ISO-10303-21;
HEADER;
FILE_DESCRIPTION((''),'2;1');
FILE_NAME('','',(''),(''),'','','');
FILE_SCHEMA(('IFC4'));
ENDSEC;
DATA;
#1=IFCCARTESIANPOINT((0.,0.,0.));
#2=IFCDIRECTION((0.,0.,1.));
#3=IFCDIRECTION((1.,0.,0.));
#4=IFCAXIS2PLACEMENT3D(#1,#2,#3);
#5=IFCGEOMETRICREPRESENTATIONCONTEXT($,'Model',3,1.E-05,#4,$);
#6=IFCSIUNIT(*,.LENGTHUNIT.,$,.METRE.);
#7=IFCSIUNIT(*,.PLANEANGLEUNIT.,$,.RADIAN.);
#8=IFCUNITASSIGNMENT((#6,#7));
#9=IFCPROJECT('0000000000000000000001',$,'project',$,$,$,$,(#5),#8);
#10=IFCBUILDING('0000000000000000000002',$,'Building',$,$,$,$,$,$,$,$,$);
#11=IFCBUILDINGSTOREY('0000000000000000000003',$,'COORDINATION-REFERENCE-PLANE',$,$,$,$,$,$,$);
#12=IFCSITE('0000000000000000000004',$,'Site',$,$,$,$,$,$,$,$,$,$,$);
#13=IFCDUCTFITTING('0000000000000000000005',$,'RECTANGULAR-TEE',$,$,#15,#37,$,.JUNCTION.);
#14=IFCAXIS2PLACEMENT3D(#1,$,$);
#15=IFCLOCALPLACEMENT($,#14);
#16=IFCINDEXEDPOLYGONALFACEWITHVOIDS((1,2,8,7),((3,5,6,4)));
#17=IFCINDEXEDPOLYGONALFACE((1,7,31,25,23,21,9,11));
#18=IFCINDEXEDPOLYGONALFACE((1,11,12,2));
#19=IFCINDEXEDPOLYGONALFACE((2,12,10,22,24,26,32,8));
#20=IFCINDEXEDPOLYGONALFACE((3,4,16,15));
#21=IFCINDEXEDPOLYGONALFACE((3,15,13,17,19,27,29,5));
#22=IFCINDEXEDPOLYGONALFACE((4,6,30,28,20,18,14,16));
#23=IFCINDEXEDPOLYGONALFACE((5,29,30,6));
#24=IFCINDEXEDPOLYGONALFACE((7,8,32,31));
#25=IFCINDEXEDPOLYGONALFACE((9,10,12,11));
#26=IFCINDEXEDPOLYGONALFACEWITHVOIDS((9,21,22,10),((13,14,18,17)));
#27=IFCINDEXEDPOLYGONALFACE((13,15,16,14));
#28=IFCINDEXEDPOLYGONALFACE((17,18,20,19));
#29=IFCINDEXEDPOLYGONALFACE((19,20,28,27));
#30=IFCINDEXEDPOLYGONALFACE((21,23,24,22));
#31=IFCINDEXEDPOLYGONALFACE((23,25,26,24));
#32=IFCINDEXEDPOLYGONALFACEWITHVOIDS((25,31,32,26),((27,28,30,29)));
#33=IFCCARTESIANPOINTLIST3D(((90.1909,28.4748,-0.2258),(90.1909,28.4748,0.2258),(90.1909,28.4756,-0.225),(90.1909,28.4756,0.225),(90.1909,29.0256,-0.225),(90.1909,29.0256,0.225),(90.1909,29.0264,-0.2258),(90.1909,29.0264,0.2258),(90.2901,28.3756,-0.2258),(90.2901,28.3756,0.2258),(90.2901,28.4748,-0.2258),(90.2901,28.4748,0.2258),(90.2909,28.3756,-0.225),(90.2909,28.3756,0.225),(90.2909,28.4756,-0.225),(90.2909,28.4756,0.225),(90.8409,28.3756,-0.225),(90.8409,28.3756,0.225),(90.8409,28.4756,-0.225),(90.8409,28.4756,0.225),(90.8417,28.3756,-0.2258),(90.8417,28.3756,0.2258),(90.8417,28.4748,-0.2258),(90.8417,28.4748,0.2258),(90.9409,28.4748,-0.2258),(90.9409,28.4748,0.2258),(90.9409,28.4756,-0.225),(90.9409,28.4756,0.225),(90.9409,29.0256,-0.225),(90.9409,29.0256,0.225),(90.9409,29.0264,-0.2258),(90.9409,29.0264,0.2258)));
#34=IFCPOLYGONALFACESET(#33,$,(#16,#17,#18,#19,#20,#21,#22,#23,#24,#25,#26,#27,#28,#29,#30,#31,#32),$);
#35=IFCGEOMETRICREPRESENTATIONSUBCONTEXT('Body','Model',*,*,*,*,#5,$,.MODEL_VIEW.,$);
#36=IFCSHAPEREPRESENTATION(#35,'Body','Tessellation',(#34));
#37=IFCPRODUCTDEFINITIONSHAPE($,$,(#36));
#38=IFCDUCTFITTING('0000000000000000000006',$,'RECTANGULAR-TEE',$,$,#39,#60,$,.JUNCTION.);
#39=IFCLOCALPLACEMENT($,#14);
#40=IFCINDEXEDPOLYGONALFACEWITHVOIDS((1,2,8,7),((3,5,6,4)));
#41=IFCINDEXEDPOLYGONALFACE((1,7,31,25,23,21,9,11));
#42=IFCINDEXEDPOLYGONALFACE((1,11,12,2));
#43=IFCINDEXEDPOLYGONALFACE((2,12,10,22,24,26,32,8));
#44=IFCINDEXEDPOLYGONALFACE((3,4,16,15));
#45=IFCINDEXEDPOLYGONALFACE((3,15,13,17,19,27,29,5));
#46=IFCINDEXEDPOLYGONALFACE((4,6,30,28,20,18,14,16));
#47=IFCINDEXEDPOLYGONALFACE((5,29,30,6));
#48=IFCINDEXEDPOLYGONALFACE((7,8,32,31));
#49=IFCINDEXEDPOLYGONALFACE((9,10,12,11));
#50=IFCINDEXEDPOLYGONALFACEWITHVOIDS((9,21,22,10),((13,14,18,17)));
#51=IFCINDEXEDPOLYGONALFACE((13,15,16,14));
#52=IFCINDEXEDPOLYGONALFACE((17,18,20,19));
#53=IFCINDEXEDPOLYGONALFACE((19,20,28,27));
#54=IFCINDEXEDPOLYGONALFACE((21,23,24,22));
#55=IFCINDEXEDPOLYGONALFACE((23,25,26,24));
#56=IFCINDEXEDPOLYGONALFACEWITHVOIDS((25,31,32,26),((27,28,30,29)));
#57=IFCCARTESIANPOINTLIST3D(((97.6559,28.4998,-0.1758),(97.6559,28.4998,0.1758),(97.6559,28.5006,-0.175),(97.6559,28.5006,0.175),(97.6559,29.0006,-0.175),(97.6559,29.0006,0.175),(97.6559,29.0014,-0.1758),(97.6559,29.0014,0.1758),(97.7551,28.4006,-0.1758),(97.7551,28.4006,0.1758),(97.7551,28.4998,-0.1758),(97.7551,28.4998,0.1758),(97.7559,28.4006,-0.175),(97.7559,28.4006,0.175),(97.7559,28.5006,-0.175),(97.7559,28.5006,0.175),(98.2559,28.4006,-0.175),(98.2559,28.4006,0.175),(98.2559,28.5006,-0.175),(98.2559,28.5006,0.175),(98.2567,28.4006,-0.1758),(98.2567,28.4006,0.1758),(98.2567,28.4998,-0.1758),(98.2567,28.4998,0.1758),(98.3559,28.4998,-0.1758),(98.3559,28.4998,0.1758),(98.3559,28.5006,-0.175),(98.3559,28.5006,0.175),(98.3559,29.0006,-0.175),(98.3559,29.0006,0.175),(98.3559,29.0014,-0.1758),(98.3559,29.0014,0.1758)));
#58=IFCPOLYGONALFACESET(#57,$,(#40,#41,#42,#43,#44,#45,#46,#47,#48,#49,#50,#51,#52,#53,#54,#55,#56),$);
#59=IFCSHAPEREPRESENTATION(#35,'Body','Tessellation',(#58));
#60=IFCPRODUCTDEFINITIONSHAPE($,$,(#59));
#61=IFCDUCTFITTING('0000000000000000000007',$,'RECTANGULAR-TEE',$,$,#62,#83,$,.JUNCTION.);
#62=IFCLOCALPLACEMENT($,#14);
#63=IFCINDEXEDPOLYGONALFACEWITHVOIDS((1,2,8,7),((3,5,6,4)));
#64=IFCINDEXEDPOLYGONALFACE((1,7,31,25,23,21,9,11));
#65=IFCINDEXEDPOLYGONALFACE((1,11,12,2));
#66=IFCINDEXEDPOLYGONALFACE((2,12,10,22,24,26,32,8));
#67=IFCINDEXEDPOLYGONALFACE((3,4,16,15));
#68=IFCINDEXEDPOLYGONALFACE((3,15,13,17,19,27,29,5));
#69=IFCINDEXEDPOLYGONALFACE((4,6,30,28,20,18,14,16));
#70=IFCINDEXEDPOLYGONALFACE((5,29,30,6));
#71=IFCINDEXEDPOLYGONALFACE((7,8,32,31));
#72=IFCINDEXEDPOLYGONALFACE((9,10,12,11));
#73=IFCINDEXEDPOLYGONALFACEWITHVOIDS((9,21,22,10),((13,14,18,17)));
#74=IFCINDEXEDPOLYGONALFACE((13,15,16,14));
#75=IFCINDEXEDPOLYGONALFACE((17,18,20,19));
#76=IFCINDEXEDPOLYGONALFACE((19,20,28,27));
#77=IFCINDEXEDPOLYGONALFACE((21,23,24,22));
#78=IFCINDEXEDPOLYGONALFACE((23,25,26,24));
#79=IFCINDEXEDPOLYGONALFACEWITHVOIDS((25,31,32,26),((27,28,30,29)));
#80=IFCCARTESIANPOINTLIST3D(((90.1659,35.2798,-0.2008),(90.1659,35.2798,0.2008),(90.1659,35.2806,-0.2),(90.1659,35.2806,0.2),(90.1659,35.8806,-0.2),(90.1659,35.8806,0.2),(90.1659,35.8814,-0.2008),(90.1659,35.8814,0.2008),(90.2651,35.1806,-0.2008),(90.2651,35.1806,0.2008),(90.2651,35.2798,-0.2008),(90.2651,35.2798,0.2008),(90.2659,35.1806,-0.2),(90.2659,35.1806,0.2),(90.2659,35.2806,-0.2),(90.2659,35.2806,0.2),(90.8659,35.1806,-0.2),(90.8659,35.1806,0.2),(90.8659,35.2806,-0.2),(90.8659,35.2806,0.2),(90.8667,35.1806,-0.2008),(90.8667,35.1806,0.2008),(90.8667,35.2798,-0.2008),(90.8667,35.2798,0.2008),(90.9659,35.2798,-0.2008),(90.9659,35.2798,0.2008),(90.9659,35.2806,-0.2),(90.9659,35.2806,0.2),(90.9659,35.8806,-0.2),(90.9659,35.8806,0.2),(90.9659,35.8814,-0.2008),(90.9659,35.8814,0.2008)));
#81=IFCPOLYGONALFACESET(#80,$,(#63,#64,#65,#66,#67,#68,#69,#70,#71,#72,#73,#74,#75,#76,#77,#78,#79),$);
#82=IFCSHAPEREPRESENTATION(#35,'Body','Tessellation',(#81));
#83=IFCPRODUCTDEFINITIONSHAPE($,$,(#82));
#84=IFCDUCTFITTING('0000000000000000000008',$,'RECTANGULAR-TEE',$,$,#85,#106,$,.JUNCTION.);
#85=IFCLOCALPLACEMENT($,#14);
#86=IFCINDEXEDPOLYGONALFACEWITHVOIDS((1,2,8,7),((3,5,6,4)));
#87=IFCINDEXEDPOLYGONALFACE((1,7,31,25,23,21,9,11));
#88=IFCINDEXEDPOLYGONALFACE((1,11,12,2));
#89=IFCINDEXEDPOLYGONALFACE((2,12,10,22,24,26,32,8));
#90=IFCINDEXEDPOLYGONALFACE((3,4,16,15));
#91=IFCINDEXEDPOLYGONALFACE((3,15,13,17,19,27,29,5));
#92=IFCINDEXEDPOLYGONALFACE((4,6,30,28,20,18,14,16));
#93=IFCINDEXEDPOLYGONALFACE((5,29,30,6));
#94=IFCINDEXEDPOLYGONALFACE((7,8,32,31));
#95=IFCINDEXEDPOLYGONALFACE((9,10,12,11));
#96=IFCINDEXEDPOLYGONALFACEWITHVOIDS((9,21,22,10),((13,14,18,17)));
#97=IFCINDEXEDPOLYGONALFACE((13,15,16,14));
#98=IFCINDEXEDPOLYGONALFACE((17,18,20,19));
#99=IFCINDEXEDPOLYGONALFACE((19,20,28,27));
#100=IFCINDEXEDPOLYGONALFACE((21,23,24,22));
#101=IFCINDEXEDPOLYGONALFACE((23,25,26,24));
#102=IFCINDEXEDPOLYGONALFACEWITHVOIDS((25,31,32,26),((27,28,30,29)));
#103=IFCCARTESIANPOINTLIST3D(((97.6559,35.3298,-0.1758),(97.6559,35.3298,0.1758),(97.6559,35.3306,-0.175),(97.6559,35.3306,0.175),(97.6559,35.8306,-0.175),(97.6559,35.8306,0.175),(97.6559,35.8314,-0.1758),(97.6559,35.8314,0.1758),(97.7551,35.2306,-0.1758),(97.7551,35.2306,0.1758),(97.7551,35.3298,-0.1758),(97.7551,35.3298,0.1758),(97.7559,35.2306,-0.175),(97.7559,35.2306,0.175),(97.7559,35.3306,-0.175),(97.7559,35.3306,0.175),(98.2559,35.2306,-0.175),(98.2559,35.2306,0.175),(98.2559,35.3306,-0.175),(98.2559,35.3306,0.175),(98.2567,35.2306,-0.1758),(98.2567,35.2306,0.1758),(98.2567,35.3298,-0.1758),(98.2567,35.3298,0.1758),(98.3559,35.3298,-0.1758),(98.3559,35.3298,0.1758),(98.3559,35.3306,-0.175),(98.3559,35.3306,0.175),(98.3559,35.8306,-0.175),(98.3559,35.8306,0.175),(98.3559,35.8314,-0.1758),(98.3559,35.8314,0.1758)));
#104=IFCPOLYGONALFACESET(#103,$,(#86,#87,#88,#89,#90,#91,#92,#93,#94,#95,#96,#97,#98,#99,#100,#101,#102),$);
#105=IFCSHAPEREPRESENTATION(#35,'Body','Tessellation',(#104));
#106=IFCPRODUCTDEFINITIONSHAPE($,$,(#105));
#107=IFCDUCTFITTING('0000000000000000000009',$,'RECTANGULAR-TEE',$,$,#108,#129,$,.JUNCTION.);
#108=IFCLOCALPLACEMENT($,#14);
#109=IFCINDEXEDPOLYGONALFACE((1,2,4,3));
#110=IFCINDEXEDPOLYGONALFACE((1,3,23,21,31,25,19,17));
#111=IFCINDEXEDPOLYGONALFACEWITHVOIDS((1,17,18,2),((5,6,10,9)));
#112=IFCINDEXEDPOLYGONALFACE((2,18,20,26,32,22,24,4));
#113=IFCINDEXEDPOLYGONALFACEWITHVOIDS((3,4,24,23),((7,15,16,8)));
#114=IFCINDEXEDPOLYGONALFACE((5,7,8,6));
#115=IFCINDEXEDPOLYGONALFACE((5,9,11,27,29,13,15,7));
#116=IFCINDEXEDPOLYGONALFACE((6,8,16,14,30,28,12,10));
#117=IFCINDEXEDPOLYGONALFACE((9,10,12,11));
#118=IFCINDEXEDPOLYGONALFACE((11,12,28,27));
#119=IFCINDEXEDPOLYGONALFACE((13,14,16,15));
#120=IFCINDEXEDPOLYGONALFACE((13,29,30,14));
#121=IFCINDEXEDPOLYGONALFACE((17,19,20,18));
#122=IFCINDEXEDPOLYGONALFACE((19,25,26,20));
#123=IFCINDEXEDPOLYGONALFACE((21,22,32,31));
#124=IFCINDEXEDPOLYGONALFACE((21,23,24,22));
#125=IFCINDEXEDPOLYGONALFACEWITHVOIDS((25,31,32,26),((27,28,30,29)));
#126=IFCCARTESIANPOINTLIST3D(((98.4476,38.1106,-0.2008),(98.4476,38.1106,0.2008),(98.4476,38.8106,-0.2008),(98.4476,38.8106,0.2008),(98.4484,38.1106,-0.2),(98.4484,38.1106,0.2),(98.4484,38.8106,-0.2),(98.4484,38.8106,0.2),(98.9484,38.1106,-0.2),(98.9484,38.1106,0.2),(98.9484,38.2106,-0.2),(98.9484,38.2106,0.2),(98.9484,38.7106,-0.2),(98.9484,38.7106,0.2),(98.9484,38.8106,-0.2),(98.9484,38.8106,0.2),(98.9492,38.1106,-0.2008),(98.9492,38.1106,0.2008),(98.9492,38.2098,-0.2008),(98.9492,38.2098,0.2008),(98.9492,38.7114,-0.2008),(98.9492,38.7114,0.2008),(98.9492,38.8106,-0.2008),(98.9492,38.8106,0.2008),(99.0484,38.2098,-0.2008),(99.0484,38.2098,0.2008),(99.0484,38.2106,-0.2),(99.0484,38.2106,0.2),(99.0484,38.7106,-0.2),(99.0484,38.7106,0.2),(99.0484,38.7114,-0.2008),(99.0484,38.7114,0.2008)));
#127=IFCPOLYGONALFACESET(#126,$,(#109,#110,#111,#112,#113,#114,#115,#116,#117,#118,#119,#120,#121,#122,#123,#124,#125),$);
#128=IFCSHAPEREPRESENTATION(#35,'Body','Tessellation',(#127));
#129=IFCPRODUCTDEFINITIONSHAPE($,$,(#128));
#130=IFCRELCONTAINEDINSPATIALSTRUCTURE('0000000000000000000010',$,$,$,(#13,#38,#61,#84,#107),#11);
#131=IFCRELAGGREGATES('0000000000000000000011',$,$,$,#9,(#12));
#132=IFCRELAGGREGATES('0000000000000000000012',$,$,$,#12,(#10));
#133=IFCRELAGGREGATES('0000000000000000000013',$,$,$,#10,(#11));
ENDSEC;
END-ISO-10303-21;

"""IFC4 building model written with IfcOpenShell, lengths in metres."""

from ifc_helpers import new_model, si_unit, frame, origin_with_axes, place, context, subcontext, project, spatial, rectangle, extrude, boolean, element, save


model = new_model("IFC4")

# Units and contexts
model_context = context("Model", 3, precision=1e-05, world=origin_with_axes())
body_context = subcontext(model_context, "Body", "Model", "MODEL_VIEW")
ifc_project = project(units=[si_unit("LENGTHUNIT", "METRE"), si_unit("PLANEANGLEUNIT", "RADIAN")], contexts=[model_context])

# Site, building, storey
site = spatial("IfcSite", under=ifc_project, Name="Site")
building = spatial("IfcBuilding", under=site, Name="Building")
storey = spatial("IfcBuildingStorey", under=building, Name="COORDINATION-REFERENCE-PLANE")

# Duct fittings
duct_fitting_1_placement = place(None, frame((90.5659, 28.7506, 0.0), z_axis=(1.0, 0.0, 0.0), x_axis=(0.0, -1.0, 0.0)))
solid_1 = boolean("UNION", extrude(rectangle(XDim=0.55, YDim=0.45), frame((0.0, 0.0, -0.375), z_axis=(0.0, 0.0, 1.0), x_axis=(1.0, 0.0, 0.0)), (0.0, 0.0, 1.0), 0.75), extrude(rectangle(XDim=0.55, YDim=0.45), frame((0.0, 0.0, 0.0), z_axis=(1.0, 0.0, 0.0), x_axis=(0.0, 0.0, -1.0)), (0.0, 0.0, 1.0), 0.375))
element("IfcDuctFitting", 1, at=duct_fitting_1_placement, inside=storey, Name="RECTANGULAR-TEE", PredefinedType="JUNCTION", context=body_context, shape_type="CSG", body=[
    boolean("DIFFERENCE", boolean("UNION", extrude(rectangle(XDim=0.5516, YDim=0.4516), frame((0.0, 0.0, -0.375), z_axis=(0.0, 0.0, 1.0), x_axis=(1.0, 0.0, 0.0)), (0.0, 0.0, 1.0), 0.75), extrude(rectangle(XDim=0.5516, YDim=0.4516), frame((0.0, 0.0, 0.0), z_axis=(1.0, 0.0, 0.0), x_axis=(0.0, 0.0, -1.0)), (0.0, 0.0, 1.0), 0.375)), solid_1),
])
duct_fitting_2_placement = place(None, frame((98.0059, 28.7506, 0.0), z_axis=(1.0, 0.0, 0.0), x_axis=(0.0, -1.0, 0.0)))
solid_2 = boolean("UNION", extrude(rectangle(XDim=0.5, YDim=0.35), frame((0.0, 0.0, -0.35), z_axis=(0.0, 0.0, 1.0), x_axis=(1.0, 0.0, 0.0)), (0.0, 0.0, 1.0), 0.7), extrude(rectangle(XDim=0.5, YDim=0.35), frame((0.0, 0.0, 0.0), z_axis=(1.0, 0.0, 0.0), x_axis=(0.0, 0.0, -1.0)), (0.0, 0.0, 1.0), 0.35))
element("IfcDuctFitting", 2, at=duct_fitting_2_placement, inside=storey, Name="RECTANGULAR-TEE", PredefinedType="JUNCTION", context=body_context, shape_type="CSG", body=[
    boolean("DIFFERENCE", boolean("UNION", extrude(rectangle(XDim=0.5016, YDim=0.3516), frame((0.0, 0.0, -0.35), z_axis=(0.0, 0.0, 1.0), x_axis=(1.0, 0.0, 0.0)), (0.0, 0.0, 1.0), 0.7), extrude(rectangle(XDim=0.5016, YDim=0.3516), frame((0.0, 0.0, 0.0), z_axis=(1.0, 0.0, 0.0), x_axis=(0.0, 0.0, -1.0)), (0.0, 0.0, 1.0), 0.35)), solid_2),
])
duct_fitting_3_placement = place(None, frame((90.5659, 35.5806, 0.0), z_axis=(1.0, 0.0, 0.0), x_axis=(0.0, -1.0, 0.0)))
solid_3 = boolean("UNION", extrude(rectangle(XDim=0.6, YDim=0.4), frame((0.0, 0.0, -0.4), z_axis=(0.0, 0.0, 1.0), x_axis=(1.0, 0.0, 0.0)), (0.0, 0.0, 1.0), 0.8), extrude(rectangle(XDim=0.6, YDim=0.4), frame((0.0, 0.0, 0.0), z_axis=(1.0, 0.0, 0.0), x_axis=(0.0, 0.0, -1.0)), (0.0, 0.0, 1.0), 0.4))
element("IfcDuctFitting", 3, at=duct_fitting_3_placement, inside=storey, Name="RECTANGULAR-TEE", PredefinedType="JUNCTION", context=body_context, shape_type="CSG", body=[
    boolean("DIFFERENCE", boolean("UNION", extrude(rectangle(XDim=0.6016, YDim=0.4016), frame((0.0, 0.0, -0.4), z_axis=(0.0, 0.0, 1.0), x_axis=(1.0, 0.0, 0.0)), (0.0, 0.0, 1.0), 0.8), extrude(rectangle(XDim=0.6016, YDim=0.4016), frame((0.0, 0.0, 0.0), z_axis=(1.0, 0.0, 0.0), x_axis=(0.0, 0.0, -1.0)), (0.0, 0.0, 1.0), 0.4)), solid_3),
])
duct_fitting_4_placement = place(None, frame((98.0059, 35.5806, 0.0), z_axis=(1.0, 0.0, 0.0), x_axis=(0.0, -1.0, 0.0)))
solid_4 = boolean("UNION", extrude(rectangle(XDim=0.5, YDim=0.35), frame((0.0, 0.0, -0.35), z_axis=(0.0, 0.0, 1.0), x_axis=(1.0, 0.0, 0.0)), (0.0, 0.0, 1.0), 0.7), extrude(rectangle(XDim=0.5, YDim=0.35), frame((0.0, 0.0, 0.0), z_axis=(1.0, 0.0, 0.0), x_axis=(0.0, 0.0, -1.0)), (0.0, 0.0, 1.0), 0.35))
element("IfcDuctFitting", 4, at=duct_fitting_4_placement, inside=storey, Name="RECTANGULAR-TEE", PredefinedType="JUNCTION", context=body_context, shape_type="CSG", body=[
    boolean("DIFFERENCE", boolean("UNION", extrude(rectangle(XDim=0.5016, YDim=0.3516), frame((0.0, 0.0, -0.35), z_axis=(0.0, 0.0, 1.0), x_axis=(1.0, 0.0, 0.0)), (0.0, 0.0, 1.0), 0.7), extrude(rectangle(XDim=0.5016, YDim=0.3516), frame((0.0, 0.0, 0.0), z_axis=(1.0, 0.0, 0.0), x_axis=(0.0, 0.0, -1.0)), (0.0, 0.0, 1.0), 0.35)), solid_4),
])
duct_fitting_5_placement = place(None, frame((98.6984, 38.4606, 0.0), z_axis=(0.0, 1.0, 0.0), x_axis=(1.0, 0.0, 0.0)))
solid_5 = boolean("UNION", extrude(rectangle(XDim=0.5, YDim=0.4), frame((0.0, 0.0, -0.35), z_axis=(0.0, 0.0, 1.0), x_axis=(1.0, 0.0, 0.0)), (0.0, 0.0, 1.0), 0.7), extrude(rectangle(XDim=0.5, YDim=0.4), frame((0.0, 0.0, 0.0), z_axis=(1.0, 0.0, 0.0), x_axis=(0.0, 0.0, -1.0)), (0.0, 0.0, 1.0), 0.35))
element("IfcDuctFitting", 5, at=duct_fitting_5_placement, inside=storey, Name="RECTANGULAR-TEE", PredefinedType="JUNCTION", context=body_context, shape_type="CSG", body=[
    boolean("DIFFERENCE", boolean("UNION", extrude(rectangle(XDim=0.5016, YDim=0.4016), frame((0.0, 0.0, -0.35), z_axis=(0.0, 0.0, 1.0), x_axis=(1.0, 0.0, 0.0)), (0.0, 0.0, 1.0), 0.7), extrude(rectangle(XDim=0.5016, YDim=0.4016), frame((0.0, 0.0, 0.0), z_axis=(1.0, 0.0, 0.0), x_axis=(0.0, 0.0, -1.0)), (0.0, 0.0, 1.0), 0.35)), solid_5),
])

save(model, "model.ifc")
